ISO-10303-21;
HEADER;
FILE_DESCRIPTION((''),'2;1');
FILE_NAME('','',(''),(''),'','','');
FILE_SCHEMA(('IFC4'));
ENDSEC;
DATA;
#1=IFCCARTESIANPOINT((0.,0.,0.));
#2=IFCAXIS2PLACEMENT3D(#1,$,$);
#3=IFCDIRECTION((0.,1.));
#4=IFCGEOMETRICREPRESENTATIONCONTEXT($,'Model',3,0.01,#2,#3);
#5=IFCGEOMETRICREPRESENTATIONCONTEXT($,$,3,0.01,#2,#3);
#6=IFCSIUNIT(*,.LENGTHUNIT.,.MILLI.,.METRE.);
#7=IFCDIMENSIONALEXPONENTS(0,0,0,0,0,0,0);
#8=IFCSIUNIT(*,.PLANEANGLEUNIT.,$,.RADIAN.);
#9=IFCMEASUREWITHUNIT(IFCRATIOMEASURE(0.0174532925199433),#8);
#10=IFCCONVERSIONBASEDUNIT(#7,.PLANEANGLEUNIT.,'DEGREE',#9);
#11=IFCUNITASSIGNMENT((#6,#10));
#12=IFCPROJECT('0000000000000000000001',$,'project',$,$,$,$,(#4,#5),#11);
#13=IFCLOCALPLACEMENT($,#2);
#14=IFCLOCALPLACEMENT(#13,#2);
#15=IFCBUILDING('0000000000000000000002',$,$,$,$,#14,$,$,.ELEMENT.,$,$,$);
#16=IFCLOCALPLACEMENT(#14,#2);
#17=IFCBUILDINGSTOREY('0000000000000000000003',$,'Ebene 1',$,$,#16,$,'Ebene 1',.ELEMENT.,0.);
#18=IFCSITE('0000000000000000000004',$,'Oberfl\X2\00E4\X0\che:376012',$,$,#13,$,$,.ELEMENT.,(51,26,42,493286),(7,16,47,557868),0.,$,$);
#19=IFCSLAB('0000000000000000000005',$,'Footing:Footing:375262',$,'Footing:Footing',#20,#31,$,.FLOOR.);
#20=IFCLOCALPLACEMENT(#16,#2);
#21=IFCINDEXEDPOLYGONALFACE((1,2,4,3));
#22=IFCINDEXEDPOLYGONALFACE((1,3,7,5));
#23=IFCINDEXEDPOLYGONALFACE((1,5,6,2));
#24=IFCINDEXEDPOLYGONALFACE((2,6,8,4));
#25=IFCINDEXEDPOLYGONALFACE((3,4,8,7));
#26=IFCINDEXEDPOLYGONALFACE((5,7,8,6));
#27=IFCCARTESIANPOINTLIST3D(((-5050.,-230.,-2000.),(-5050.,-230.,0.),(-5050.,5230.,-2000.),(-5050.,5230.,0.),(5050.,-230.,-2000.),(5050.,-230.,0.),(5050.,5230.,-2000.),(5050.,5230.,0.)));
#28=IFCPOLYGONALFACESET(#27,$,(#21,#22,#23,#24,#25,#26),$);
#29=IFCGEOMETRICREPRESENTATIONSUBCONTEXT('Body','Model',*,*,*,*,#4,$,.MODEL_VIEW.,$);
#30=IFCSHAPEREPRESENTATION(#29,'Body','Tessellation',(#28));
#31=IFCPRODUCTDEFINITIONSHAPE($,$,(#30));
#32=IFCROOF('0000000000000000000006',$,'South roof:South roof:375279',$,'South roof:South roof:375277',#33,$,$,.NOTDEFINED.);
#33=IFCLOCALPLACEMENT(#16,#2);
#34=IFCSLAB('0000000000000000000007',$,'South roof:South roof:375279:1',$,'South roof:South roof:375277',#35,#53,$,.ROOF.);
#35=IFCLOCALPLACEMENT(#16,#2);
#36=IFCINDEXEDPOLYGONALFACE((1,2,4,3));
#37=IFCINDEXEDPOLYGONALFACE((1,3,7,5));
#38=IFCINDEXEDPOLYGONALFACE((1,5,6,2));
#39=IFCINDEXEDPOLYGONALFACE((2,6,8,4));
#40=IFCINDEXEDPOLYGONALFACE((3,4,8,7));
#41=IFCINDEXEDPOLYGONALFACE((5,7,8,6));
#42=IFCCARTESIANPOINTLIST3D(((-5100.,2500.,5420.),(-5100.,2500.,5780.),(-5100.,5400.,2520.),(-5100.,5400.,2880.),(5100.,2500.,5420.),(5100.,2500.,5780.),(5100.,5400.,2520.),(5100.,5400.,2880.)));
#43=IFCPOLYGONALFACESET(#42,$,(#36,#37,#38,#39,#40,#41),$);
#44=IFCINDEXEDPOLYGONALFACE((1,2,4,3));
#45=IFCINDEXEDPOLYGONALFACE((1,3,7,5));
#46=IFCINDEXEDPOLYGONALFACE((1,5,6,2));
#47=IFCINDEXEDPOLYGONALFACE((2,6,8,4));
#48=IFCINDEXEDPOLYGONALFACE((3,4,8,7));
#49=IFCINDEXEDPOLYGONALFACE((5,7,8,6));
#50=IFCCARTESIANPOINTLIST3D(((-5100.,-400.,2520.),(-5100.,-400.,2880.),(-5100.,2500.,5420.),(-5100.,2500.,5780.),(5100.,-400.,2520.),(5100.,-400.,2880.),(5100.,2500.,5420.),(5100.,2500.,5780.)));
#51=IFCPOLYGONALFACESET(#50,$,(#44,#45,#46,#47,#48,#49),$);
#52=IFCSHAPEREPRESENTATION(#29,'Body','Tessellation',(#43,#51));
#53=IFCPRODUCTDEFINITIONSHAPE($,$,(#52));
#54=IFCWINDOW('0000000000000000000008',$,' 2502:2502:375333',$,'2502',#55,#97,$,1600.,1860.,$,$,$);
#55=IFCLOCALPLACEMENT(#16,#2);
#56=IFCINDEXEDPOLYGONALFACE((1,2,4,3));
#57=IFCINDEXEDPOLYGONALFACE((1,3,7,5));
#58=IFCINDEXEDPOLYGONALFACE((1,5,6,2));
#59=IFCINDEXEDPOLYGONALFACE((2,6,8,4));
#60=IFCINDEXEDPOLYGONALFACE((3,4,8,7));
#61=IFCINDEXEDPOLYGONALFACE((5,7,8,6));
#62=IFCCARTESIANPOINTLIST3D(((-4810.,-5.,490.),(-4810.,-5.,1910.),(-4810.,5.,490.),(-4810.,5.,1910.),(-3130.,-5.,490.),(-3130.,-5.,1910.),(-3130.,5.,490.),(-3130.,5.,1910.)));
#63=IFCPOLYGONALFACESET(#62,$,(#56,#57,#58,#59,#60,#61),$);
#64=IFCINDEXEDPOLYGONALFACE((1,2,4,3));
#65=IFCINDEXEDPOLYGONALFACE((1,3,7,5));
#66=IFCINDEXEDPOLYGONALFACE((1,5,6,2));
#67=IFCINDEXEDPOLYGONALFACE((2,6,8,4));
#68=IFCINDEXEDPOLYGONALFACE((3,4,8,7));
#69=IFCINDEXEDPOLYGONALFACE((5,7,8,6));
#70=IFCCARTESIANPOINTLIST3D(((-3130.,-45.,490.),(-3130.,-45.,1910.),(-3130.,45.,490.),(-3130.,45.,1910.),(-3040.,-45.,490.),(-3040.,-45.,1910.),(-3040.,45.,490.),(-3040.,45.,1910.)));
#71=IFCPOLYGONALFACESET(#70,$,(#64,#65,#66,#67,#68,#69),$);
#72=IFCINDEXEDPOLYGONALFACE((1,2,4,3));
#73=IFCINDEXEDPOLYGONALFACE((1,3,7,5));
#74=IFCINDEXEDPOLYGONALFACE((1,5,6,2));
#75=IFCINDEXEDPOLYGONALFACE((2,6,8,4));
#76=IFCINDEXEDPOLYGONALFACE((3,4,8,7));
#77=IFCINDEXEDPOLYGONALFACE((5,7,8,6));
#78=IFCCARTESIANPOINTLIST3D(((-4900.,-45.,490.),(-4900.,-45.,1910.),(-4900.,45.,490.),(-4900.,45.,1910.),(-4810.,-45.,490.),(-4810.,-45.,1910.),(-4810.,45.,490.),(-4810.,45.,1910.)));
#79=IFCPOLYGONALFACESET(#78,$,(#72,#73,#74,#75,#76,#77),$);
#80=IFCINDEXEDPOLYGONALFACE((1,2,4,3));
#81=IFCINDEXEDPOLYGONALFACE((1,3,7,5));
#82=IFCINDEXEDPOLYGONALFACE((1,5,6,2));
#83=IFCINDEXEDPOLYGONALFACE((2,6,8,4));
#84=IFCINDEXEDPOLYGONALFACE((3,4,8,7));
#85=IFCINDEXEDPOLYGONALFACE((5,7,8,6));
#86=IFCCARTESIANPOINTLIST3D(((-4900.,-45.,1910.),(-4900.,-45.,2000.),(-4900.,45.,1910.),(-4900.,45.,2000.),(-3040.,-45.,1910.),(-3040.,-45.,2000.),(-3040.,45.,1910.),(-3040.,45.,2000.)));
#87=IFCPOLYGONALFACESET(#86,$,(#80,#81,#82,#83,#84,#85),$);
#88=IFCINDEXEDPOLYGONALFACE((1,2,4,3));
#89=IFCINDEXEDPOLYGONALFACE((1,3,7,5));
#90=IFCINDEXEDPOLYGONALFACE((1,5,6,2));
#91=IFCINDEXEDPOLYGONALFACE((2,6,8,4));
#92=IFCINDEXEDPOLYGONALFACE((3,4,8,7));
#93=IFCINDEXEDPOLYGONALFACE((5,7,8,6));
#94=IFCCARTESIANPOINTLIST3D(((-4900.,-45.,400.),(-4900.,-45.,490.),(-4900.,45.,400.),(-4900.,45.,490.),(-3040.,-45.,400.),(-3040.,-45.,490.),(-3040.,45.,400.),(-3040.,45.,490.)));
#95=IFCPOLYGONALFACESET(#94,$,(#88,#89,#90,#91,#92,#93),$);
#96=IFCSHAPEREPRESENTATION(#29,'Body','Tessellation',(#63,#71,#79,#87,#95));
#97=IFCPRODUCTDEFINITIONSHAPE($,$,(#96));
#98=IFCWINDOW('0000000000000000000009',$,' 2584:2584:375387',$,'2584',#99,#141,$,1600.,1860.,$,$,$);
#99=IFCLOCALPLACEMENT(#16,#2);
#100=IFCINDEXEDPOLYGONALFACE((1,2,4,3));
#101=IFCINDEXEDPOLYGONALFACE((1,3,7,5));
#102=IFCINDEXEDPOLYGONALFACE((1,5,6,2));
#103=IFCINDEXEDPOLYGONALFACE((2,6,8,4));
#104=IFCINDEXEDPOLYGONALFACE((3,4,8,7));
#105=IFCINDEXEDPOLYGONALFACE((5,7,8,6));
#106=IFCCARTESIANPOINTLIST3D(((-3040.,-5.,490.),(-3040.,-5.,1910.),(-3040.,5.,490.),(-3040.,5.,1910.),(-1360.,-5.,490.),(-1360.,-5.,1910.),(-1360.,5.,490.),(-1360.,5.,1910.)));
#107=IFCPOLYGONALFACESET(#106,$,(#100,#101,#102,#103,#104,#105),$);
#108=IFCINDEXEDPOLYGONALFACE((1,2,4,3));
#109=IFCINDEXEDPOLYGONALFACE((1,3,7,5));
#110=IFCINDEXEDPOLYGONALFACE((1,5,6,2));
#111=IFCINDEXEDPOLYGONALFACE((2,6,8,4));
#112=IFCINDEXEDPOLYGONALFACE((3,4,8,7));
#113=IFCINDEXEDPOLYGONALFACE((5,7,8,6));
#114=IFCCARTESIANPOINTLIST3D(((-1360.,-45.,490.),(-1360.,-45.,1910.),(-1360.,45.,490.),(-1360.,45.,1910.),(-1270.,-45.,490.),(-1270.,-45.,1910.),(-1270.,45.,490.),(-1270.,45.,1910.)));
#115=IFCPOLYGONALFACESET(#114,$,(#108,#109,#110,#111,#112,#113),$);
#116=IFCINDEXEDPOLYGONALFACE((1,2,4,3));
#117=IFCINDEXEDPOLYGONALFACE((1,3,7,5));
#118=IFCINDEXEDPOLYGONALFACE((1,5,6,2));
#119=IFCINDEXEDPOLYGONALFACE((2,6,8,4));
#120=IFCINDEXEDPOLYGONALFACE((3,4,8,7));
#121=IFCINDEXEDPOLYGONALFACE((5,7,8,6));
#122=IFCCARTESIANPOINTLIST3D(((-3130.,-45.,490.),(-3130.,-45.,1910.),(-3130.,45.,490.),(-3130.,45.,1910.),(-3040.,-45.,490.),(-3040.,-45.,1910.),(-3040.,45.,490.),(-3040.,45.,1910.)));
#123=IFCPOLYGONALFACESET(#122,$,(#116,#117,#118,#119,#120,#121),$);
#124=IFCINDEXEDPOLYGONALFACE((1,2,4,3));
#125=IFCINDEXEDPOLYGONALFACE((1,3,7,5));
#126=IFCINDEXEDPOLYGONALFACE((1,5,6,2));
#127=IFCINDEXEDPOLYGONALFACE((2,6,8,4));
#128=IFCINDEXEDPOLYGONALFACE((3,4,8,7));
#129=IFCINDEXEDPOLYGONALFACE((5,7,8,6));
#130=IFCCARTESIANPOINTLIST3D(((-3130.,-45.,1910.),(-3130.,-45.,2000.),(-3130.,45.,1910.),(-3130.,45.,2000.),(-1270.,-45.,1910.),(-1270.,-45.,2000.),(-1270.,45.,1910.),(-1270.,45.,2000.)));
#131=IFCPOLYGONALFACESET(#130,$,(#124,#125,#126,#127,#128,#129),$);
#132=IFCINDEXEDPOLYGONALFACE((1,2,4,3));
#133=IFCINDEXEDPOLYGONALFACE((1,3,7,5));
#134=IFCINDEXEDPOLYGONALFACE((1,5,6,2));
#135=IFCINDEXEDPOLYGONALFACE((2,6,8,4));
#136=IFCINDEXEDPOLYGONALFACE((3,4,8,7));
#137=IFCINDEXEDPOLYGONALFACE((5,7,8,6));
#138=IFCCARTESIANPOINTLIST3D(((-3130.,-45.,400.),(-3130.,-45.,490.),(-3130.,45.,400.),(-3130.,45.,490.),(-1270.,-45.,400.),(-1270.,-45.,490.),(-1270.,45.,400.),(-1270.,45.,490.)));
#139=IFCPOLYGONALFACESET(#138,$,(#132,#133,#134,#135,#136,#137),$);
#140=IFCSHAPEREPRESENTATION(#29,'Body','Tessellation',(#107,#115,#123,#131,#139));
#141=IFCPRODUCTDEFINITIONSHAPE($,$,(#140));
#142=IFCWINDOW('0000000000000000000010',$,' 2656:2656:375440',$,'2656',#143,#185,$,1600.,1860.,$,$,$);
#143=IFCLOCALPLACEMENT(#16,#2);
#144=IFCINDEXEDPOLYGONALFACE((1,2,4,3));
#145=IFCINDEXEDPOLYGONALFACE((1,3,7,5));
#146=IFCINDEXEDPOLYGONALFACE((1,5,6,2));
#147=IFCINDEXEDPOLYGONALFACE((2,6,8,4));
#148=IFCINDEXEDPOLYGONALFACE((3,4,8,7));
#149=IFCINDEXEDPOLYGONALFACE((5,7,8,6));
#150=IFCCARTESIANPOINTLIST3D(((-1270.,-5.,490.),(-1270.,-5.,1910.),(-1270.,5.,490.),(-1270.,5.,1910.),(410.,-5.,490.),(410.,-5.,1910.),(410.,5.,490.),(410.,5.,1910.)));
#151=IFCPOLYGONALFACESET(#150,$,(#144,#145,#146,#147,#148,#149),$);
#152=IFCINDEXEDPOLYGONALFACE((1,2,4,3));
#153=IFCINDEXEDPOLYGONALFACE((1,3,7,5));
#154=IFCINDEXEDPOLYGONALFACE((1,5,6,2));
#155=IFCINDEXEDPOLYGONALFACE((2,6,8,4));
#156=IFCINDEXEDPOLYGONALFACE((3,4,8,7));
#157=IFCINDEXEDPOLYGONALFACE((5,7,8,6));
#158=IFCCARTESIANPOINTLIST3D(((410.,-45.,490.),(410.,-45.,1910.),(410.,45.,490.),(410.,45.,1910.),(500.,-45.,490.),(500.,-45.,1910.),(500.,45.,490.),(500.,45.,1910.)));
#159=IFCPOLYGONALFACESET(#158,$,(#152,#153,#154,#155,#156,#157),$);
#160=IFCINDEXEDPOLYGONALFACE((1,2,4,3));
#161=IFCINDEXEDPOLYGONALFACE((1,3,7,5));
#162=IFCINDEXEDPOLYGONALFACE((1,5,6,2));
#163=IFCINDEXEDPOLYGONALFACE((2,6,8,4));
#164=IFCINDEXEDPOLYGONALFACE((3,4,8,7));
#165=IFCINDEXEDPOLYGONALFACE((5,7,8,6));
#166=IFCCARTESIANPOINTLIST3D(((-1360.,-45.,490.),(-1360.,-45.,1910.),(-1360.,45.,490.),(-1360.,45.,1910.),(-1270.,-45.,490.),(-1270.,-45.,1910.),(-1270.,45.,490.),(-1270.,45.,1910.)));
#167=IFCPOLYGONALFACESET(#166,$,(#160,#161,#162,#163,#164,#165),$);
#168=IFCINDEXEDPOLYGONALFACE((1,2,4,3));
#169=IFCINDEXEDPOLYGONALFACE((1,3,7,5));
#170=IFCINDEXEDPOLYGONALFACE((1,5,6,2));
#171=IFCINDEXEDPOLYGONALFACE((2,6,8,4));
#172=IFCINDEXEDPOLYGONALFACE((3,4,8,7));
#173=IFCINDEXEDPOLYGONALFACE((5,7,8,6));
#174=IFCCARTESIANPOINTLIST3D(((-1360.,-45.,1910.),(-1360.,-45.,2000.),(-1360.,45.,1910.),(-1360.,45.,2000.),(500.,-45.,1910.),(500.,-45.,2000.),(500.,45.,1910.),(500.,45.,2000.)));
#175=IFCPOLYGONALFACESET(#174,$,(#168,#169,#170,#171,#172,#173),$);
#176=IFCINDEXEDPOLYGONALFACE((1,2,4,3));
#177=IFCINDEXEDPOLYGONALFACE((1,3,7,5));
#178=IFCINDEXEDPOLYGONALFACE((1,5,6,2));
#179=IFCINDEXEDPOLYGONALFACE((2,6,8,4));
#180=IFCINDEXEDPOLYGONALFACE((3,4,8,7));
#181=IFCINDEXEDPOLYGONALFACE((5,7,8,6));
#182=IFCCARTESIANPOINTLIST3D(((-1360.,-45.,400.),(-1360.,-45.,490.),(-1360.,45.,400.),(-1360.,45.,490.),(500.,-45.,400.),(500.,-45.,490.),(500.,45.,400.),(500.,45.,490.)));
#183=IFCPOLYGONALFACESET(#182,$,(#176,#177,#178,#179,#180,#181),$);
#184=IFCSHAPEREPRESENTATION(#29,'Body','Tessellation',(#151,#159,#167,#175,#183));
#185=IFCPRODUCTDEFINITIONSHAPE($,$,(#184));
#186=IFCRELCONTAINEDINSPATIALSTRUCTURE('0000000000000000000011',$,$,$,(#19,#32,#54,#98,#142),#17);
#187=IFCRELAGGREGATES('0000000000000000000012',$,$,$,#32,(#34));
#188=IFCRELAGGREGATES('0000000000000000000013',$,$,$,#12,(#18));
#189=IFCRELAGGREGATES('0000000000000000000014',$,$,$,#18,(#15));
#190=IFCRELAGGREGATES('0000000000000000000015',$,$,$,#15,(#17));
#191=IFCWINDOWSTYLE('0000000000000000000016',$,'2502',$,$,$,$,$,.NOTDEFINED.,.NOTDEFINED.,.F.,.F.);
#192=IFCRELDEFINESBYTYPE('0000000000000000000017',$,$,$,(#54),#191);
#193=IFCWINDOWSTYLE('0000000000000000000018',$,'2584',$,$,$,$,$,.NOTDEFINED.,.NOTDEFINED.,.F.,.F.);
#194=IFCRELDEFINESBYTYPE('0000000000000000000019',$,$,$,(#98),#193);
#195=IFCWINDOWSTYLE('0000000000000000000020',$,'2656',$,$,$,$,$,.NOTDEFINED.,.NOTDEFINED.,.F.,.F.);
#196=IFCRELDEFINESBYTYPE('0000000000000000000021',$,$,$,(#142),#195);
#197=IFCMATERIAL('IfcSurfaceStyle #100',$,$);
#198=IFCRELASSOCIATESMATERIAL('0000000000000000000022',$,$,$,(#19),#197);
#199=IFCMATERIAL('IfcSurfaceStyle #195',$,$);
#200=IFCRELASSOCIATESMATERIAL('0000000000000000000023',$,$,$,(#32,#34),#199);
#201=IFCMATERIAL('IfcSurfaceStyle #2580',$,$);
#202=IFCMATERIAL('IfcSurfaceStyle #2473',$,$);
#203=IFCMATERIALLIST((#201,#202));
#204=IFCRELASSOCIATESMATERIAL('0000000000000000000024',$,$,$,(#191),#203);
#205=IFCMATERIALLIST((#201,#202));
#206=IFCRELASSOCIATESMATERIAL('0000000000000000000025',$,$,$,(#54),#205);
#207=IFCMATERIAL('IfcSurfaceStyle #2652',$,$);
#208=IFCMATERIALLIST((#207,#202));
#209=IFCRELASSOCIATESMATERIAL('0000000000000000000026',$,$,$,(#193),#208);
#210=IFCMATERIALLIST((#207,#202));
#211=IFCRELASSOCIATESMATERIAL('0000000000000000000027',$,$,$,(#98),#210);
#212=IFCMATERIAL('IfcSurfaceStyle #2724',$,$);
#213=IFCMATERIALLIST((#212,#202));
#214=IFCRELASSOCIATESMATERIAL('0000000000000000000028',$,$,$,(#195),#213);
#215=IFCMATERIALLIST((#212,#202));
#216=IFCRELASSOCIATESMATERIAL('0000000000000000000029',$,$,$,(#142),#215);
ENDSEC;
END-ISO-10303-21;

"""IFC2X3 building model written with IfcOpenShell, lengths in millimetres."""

from ifc_helpers import new_model, entity, si_unit, converted_unit, direction, frame, frame_2d, origin, origin_2d_with_axis, place, context, subcontext, project, spatial, polyline, rectangle, outline, extrude, source, transform, mapped, material, material_list, type_object, type_shapes, element, aggregate, save


model = new_model("IFC2X3")

# Units and contexts
model_context = context("Model", 3, precision=0.01, world=origin(), true_north=direction((0.0, 1.0)))
context_of_model = context(None, 3, precision=0.01, world=origin(), true_north=direction((0.0, 1.0)))
body_context = subcontext(model_context, "Body", "Model", "MODEL_VIEW")
ifc_project = project(units=[si_unit("LENGTHUNIT", "METRE", prefix="MILLI"), converted_unit("PLANEANGLEUNIT", "DEGREE", entity("IfcRatioMeasure", 0.0174532925199433), si_unit("PLANEANGLEUNIT", "RADIAN"), dimensions=[0, 0, 0, 0, 0, 0, 0])], contexts=[model_context, context_of_model])

# Site, building, storey
site_placement = place(None, origin())
site = spatial("IfcSite", under=ifc_project, at=site_placement, Name="Oberfläche:376012", CompositionType="ELEMENT", RefLatitude=(51, 26, 42, 493286), RefLongitude=(7, 16, 47, 557868), RefElevation=0.0)
building_placement = place(site_placement, origin())
building = spatial("IfcBuilding", under=site, at=building_placement, CompositionType="ELEMENT")
storey_placement = place(building_placement, origin())
storey = spatial("IfcBuildingStorey", under=building, at=storey_placement, Name="Ebene 1", LongName="Ebene 1", CompositionType="ELEMENT", Elevation=0.0)

# Slab
ifc_material_1 = material(Name="IfcSurfaceStyle #100")
slab_1_placement = place(storey_placement, origin())
element("IfcSlab", 1, at=slab_1_placement, inside=storey, material=ifc_material_1, Name="Footing:Footing:375262", ObjectType="Footing:Footing", PredefinedType="FLOOR", context=body_context, shape_type="SweptSolid", body=[
    extrude(rectangle(XDim=5460.0, YDim=10100.0, at=frame_2d((0.0, 0.0), x_axis=(1.0, 0.0))), frame((0.0, 2500.0, -2000.0), z_axis=(0.0, 0.0, 1.0), x_axis=(0.0, 1.0, 0.0)), (0.0, 0.0, 1.0), 2000.0),
])

# Roof, slab
ifc_material_2 = material(Name="IfcSurfaceStyle #195")
roof_placement = place(storey_placement, origin())
roof = element("IfcRoof", 2, at=roof_placement, inside=storey, material=ifc_material_2, Name="South roof:South roof:375279", ObjectType="South roof:South roof:375277", ShapeType="NOTDEFINED")
slab_2_placement = place(storey_placement, origin())
slab_2 = element("IfcSlab", 3, at=slab_2_placement, material=ifc_material_2, Name="South roof:South roof:375279:1", ObjectType="South roof:South roof:375277", PredefinedType="ROOF", context=body_context, shape_type="SweptSolid", body=[
    extrude(outline(polyline([(-1923.3, -127.3), (2177.9, -127.3), (1923.3, 127.3), (-2177.9, 127.3), (-1923.3, -127.3)])), frame((-5100.0, 3950.0, 4150.0), z_axis=(1.0, 0.0, 0.0), x_axis=(0.0, -0.707107, 0.707107)), (0.0, 0.0, 1.0), 10200.0),
    extrude(outline(polyline([(-2177.9, -127.3), (1923.3, -127.3), (2177.9, 127.3), (-1923.3, 127.3), (-2177.9, -127.3)])), frame((-5100.0, 1050.0, 4150.0), z_axis=(1.0, 0.0, 0.0), x_axis=(0.0, 0.707107, 0.707107)), (0.0, 0.0, 1.0), 10200.0),
])
aggregate(roof, [slab_2])

# Windows
ifc_material_3 = material(Name="IfcSurfaceStyle #2580")
ifc_material_4 = material(Name="IfcSurfaceStyle #2473")
ifc_material_list_1 = material_list([ifc_material_3, ifc_material_4])
ifc_material_list_2 = material_list([ifc_material_3, ifc_material_4])
window_style_1 = type_object("IfcWindowStyle", Name="2502", ConstructionType="NOTDEFINED", OperationType="NOTDEFINED", ParameterTakesPrecedence=False, Sizeable=False, material=ifc_material_list_2)
shared_shape_1 = source(origin(), body_context, "Body", "SweptSolid", [
    extrude(rectangle(XDim=10.0, YDim=1680.0, at=origin_2d_with_axis()), frame((-3970.0, 0.0, 490.0), z_axis=(0.0, 0.0, 1.0), x_axis=(0.0, 1.0, 0.0)), (0.0, 0.0, 1.0), 1420.0),
    extrude(rectangle(XDim=90.0, YDim=90.0, at=frame_2d((0.0, 0.0), x_axis=(1.0, 0.0))), frame((-3085.0, 0.0, 490.0), z_axis=(0.0, 0.0, 1.0), x_axis=(0.0, 1.0, 0.0)), (0.0, 0.0, 1.0), 1420.0),
    extrude(rectangle(XDim=90.0, YDim=90.0, at=frame_2d((0.0, 0.0), x_axis=(1.0, 0.0))), frame((-4855.0, 0.0, 490.0), z_axis=(0.0, 0.0, 1.0), x_axis=(0.0, 1.0, 0.0)), (0.0, 0.0, 1.0), 1420.0),
    extrude(rectangle(XDim=90.0, YDim=1860.0, at=frame_2d((0.0, 0.0), x_axis=(1.0, 0.0))), frame((-3970.0, 0.0, 1910.0), z_axis=(0.0, 0.0, 1.0), x_axis=(0.0, 1.0, 0.0)), (0.0, 0.0, 1.0), 90.0),
    extrude(rectangle(XDim=90.0, YDim=1860.0, at=frame_2d((0.0, 0.0), x_axis=(1.0, 0.0))), frame((-3970.0, 0.0, 400.0), z_axis=(0.0, 0.0, 1.0), x_axis=(0.0, 1.0, 0.0)), (0.0, 0.0, 1.0), 90.0),
])
type_shapes(window_style_1, [shared_shape_1])
window_1_placement = place(storey_placement, origin())
element("IfcWindow", 4, at=window_1_placement, inside=storey, type_object=window_style_1, material=ifc_material_list_1, Name=" 2502:2502:375333", ObjectType="2502", OverallHeight=1600.0, OverallWidth=1860.0, context=body_context, shape_type="MappedRepresentation", body=[
    mapped(shared_shape_1, transform((0.0, 0.0, 0.0), scale=1.0)),
])
ifc_material_5 = material(Name="IfcSurfaceStyle #2652")
ifc_material_list_3 = material_list([ifc_material_5, ifc_material_4])
ifc_material_list_4 = material_list([ifc_material_5, ifc_material_4])
window_style_2 = type_object("IfcWindowStyle", Name="2584", ConstructionType="NOTDEFINED", OperationType="NOTDEFINED", ParameterTakesPrecedence=False, Sizeable=False, material=ifc_material_list_4)
shared_shape_2 = source(origin(), body_context, "Body", "SweptSolid", [
    extrude(rectangle(XDim=10.0, YDim=1680.0, at=origin_2d_with_axis()), frame((-2200.0, 0.0, 490.0), z_axis=(0.0, 0.0, 1.0), x_axis=(0.0, 1.0, 0.0)), (0.0, 0.0, 1.0), 1420.0),
    extrude(rectangle(XDim=90.0, YDim=90.0, at=frame_2d((0.0, 0.0), x_axis=(1.0, 0.0))), frame((-1315.0, 0.0, 490.0), z_axis=(0.0, 0.0, 1.0), x_axis=(0.0, 1.0, 0.0)), (0.0, 0.0, 1.0), 1420.0),
    extrude(rectangle(XDim=90.0, YDim=90.0, at=frame_2d((0.0, 0.0), x_axis=(1.0, 0.0))), frame((-3085.0, 0.0, 490.0), z_axis=(0.0, 0.0, 1.0), x_axis=(0.0, 1.0, 0.0)), (0.0, 0.0, 1.0), 1420.0),
    extrude(rectangle(XDim=90.0, YDim=1860.0, at=frame_2d((0.0, 0.0), x_axis=(1.0, 0.0))), frame((-2200.0, 0.0, 1910.0), z_axis=(0.0, 0.0, 1.0), x_axis=(0.0, 1.0, 0.0)), (0.0, 0.0, 1.0), 90.0),
    extrude(rectangle(XDim=90.0, YDim=1860.0, at=frame_2d((0.0, 0.0), x_axis=(1.0, 0.0))), frame((-2200.0, 0.0, 400.0), z_axis=(0.0, 0.0, 1.0), x_axis=(0.0, 1.0, 0.0)), (0.0, 0.0, 1.0), 90.0),
])
type_shapes(window_style_2, [shared_shape_2])
window_2_placement = place(storey_placement, origin())
element("IfcWindow", 5, at=window_2_placement, inside=storey, type_object=window_style_2, material=ifc_material_list_3, Name=" 2584:2584:375387", ObjectType="2584", OverallHeight=1600.0, OverallWidth=1860.0, context=body_context, shape_type="MappedRepresentation", body=[
    mapped(shared_shape_2, transform((0.0, 0.0, 0.0), scale=1.0)),
])
ifc_material_6 = material(Name="IfcSurfaceStyle #2724")
ifc_material_list_5 = material_list([ifc_material_6, ifc_material_4])
ifc_material_list_6 = material_list([ifc_material_6, ifc_material_4])
window_style_3 = type_object("IfcWindowStyle", Name="2656", ConstructionType="NOTDEFINED", OperationType="NOTDEFINED", ParameterTakesPrecedence=False, Sizeable=False, material=ifc_material_list_6)
shared_shape_3 = source(origin(), body_context, "Body", "SweptSolid", [
    extrude(rectangle(XDim=10.0, YDim=1680.0, at=origin_2d_with_axis()), frame((-430.0, 0.0, 490.0), z_axis=(0.0, 0.0, 1.0), x_axis=(0.0, 1.0, 0.0)), (0.0, 0.0, 1.0), 1420.0),
    extrude(rectangle(XDim=90.0, YDim=90.0, at=frame_2d((0.0, 0.0), x_axis=(1.0, 0.0))), frame((455.0, 0.0, 490.0), z_axis=(0.0, 0.0, 1.0), x_axis=(0.0, 1.0, 0.0)), (0.0, 0.0, 1.0), 1420.0),
    extrude(rectangle(XDim=90.0, YDim=90.0, at=frame_2d((0.0, 0.0), x_axis=(1.0, 0.0))), frame((-1315.0, 0.0, 490.0), z_axis=(0.0, 0.0, 1.0), x_axis=(0.0, 1.0, 0.0)), (0.0, 0.0, 1.0), 1420.0),
    extrude(rectangle(XDim=90.0, YDim=1860.0, at=origin_2d_with_axis()), frame((-430.0, 0.0, 1910.0), z_axis=(0.0, 0.0, 1.0), x_axis=(0.0, 1.0, 0.0)), (0.0, 0.0, 1.0), 90.0),
    extrude(rectangle(XDim=90.0, YDim=1860.0, at=origin_2d_with_axis()), frame((-430.0, 0.0, 400.0), z_axis=(0.0, 0.0, 1.0), x_axis=(0.0, 1.0, 0.0)), (0.0, 0.0, 1.0), 90.0),
])
type_shapes(window_style_3, [shared_shape_3])
window_3_placement = place(storey_placement, origin())
element("IfcWindow", 6, at=window_3_placement, inside=storey, type_object=window_style_3, material=ifc_material_list_5, Name=" 2656:2656:375440", ObjectType="2656", OverallHeight=1600.0, OverallWidth=1860.0, context=body_context, shape_type="MappedRepresentation", body=[
    mapped(shared_shape_3, transform((0.0, 0.0, 0.0), scale=1.0)),
])

save(model, "model.ifc")
